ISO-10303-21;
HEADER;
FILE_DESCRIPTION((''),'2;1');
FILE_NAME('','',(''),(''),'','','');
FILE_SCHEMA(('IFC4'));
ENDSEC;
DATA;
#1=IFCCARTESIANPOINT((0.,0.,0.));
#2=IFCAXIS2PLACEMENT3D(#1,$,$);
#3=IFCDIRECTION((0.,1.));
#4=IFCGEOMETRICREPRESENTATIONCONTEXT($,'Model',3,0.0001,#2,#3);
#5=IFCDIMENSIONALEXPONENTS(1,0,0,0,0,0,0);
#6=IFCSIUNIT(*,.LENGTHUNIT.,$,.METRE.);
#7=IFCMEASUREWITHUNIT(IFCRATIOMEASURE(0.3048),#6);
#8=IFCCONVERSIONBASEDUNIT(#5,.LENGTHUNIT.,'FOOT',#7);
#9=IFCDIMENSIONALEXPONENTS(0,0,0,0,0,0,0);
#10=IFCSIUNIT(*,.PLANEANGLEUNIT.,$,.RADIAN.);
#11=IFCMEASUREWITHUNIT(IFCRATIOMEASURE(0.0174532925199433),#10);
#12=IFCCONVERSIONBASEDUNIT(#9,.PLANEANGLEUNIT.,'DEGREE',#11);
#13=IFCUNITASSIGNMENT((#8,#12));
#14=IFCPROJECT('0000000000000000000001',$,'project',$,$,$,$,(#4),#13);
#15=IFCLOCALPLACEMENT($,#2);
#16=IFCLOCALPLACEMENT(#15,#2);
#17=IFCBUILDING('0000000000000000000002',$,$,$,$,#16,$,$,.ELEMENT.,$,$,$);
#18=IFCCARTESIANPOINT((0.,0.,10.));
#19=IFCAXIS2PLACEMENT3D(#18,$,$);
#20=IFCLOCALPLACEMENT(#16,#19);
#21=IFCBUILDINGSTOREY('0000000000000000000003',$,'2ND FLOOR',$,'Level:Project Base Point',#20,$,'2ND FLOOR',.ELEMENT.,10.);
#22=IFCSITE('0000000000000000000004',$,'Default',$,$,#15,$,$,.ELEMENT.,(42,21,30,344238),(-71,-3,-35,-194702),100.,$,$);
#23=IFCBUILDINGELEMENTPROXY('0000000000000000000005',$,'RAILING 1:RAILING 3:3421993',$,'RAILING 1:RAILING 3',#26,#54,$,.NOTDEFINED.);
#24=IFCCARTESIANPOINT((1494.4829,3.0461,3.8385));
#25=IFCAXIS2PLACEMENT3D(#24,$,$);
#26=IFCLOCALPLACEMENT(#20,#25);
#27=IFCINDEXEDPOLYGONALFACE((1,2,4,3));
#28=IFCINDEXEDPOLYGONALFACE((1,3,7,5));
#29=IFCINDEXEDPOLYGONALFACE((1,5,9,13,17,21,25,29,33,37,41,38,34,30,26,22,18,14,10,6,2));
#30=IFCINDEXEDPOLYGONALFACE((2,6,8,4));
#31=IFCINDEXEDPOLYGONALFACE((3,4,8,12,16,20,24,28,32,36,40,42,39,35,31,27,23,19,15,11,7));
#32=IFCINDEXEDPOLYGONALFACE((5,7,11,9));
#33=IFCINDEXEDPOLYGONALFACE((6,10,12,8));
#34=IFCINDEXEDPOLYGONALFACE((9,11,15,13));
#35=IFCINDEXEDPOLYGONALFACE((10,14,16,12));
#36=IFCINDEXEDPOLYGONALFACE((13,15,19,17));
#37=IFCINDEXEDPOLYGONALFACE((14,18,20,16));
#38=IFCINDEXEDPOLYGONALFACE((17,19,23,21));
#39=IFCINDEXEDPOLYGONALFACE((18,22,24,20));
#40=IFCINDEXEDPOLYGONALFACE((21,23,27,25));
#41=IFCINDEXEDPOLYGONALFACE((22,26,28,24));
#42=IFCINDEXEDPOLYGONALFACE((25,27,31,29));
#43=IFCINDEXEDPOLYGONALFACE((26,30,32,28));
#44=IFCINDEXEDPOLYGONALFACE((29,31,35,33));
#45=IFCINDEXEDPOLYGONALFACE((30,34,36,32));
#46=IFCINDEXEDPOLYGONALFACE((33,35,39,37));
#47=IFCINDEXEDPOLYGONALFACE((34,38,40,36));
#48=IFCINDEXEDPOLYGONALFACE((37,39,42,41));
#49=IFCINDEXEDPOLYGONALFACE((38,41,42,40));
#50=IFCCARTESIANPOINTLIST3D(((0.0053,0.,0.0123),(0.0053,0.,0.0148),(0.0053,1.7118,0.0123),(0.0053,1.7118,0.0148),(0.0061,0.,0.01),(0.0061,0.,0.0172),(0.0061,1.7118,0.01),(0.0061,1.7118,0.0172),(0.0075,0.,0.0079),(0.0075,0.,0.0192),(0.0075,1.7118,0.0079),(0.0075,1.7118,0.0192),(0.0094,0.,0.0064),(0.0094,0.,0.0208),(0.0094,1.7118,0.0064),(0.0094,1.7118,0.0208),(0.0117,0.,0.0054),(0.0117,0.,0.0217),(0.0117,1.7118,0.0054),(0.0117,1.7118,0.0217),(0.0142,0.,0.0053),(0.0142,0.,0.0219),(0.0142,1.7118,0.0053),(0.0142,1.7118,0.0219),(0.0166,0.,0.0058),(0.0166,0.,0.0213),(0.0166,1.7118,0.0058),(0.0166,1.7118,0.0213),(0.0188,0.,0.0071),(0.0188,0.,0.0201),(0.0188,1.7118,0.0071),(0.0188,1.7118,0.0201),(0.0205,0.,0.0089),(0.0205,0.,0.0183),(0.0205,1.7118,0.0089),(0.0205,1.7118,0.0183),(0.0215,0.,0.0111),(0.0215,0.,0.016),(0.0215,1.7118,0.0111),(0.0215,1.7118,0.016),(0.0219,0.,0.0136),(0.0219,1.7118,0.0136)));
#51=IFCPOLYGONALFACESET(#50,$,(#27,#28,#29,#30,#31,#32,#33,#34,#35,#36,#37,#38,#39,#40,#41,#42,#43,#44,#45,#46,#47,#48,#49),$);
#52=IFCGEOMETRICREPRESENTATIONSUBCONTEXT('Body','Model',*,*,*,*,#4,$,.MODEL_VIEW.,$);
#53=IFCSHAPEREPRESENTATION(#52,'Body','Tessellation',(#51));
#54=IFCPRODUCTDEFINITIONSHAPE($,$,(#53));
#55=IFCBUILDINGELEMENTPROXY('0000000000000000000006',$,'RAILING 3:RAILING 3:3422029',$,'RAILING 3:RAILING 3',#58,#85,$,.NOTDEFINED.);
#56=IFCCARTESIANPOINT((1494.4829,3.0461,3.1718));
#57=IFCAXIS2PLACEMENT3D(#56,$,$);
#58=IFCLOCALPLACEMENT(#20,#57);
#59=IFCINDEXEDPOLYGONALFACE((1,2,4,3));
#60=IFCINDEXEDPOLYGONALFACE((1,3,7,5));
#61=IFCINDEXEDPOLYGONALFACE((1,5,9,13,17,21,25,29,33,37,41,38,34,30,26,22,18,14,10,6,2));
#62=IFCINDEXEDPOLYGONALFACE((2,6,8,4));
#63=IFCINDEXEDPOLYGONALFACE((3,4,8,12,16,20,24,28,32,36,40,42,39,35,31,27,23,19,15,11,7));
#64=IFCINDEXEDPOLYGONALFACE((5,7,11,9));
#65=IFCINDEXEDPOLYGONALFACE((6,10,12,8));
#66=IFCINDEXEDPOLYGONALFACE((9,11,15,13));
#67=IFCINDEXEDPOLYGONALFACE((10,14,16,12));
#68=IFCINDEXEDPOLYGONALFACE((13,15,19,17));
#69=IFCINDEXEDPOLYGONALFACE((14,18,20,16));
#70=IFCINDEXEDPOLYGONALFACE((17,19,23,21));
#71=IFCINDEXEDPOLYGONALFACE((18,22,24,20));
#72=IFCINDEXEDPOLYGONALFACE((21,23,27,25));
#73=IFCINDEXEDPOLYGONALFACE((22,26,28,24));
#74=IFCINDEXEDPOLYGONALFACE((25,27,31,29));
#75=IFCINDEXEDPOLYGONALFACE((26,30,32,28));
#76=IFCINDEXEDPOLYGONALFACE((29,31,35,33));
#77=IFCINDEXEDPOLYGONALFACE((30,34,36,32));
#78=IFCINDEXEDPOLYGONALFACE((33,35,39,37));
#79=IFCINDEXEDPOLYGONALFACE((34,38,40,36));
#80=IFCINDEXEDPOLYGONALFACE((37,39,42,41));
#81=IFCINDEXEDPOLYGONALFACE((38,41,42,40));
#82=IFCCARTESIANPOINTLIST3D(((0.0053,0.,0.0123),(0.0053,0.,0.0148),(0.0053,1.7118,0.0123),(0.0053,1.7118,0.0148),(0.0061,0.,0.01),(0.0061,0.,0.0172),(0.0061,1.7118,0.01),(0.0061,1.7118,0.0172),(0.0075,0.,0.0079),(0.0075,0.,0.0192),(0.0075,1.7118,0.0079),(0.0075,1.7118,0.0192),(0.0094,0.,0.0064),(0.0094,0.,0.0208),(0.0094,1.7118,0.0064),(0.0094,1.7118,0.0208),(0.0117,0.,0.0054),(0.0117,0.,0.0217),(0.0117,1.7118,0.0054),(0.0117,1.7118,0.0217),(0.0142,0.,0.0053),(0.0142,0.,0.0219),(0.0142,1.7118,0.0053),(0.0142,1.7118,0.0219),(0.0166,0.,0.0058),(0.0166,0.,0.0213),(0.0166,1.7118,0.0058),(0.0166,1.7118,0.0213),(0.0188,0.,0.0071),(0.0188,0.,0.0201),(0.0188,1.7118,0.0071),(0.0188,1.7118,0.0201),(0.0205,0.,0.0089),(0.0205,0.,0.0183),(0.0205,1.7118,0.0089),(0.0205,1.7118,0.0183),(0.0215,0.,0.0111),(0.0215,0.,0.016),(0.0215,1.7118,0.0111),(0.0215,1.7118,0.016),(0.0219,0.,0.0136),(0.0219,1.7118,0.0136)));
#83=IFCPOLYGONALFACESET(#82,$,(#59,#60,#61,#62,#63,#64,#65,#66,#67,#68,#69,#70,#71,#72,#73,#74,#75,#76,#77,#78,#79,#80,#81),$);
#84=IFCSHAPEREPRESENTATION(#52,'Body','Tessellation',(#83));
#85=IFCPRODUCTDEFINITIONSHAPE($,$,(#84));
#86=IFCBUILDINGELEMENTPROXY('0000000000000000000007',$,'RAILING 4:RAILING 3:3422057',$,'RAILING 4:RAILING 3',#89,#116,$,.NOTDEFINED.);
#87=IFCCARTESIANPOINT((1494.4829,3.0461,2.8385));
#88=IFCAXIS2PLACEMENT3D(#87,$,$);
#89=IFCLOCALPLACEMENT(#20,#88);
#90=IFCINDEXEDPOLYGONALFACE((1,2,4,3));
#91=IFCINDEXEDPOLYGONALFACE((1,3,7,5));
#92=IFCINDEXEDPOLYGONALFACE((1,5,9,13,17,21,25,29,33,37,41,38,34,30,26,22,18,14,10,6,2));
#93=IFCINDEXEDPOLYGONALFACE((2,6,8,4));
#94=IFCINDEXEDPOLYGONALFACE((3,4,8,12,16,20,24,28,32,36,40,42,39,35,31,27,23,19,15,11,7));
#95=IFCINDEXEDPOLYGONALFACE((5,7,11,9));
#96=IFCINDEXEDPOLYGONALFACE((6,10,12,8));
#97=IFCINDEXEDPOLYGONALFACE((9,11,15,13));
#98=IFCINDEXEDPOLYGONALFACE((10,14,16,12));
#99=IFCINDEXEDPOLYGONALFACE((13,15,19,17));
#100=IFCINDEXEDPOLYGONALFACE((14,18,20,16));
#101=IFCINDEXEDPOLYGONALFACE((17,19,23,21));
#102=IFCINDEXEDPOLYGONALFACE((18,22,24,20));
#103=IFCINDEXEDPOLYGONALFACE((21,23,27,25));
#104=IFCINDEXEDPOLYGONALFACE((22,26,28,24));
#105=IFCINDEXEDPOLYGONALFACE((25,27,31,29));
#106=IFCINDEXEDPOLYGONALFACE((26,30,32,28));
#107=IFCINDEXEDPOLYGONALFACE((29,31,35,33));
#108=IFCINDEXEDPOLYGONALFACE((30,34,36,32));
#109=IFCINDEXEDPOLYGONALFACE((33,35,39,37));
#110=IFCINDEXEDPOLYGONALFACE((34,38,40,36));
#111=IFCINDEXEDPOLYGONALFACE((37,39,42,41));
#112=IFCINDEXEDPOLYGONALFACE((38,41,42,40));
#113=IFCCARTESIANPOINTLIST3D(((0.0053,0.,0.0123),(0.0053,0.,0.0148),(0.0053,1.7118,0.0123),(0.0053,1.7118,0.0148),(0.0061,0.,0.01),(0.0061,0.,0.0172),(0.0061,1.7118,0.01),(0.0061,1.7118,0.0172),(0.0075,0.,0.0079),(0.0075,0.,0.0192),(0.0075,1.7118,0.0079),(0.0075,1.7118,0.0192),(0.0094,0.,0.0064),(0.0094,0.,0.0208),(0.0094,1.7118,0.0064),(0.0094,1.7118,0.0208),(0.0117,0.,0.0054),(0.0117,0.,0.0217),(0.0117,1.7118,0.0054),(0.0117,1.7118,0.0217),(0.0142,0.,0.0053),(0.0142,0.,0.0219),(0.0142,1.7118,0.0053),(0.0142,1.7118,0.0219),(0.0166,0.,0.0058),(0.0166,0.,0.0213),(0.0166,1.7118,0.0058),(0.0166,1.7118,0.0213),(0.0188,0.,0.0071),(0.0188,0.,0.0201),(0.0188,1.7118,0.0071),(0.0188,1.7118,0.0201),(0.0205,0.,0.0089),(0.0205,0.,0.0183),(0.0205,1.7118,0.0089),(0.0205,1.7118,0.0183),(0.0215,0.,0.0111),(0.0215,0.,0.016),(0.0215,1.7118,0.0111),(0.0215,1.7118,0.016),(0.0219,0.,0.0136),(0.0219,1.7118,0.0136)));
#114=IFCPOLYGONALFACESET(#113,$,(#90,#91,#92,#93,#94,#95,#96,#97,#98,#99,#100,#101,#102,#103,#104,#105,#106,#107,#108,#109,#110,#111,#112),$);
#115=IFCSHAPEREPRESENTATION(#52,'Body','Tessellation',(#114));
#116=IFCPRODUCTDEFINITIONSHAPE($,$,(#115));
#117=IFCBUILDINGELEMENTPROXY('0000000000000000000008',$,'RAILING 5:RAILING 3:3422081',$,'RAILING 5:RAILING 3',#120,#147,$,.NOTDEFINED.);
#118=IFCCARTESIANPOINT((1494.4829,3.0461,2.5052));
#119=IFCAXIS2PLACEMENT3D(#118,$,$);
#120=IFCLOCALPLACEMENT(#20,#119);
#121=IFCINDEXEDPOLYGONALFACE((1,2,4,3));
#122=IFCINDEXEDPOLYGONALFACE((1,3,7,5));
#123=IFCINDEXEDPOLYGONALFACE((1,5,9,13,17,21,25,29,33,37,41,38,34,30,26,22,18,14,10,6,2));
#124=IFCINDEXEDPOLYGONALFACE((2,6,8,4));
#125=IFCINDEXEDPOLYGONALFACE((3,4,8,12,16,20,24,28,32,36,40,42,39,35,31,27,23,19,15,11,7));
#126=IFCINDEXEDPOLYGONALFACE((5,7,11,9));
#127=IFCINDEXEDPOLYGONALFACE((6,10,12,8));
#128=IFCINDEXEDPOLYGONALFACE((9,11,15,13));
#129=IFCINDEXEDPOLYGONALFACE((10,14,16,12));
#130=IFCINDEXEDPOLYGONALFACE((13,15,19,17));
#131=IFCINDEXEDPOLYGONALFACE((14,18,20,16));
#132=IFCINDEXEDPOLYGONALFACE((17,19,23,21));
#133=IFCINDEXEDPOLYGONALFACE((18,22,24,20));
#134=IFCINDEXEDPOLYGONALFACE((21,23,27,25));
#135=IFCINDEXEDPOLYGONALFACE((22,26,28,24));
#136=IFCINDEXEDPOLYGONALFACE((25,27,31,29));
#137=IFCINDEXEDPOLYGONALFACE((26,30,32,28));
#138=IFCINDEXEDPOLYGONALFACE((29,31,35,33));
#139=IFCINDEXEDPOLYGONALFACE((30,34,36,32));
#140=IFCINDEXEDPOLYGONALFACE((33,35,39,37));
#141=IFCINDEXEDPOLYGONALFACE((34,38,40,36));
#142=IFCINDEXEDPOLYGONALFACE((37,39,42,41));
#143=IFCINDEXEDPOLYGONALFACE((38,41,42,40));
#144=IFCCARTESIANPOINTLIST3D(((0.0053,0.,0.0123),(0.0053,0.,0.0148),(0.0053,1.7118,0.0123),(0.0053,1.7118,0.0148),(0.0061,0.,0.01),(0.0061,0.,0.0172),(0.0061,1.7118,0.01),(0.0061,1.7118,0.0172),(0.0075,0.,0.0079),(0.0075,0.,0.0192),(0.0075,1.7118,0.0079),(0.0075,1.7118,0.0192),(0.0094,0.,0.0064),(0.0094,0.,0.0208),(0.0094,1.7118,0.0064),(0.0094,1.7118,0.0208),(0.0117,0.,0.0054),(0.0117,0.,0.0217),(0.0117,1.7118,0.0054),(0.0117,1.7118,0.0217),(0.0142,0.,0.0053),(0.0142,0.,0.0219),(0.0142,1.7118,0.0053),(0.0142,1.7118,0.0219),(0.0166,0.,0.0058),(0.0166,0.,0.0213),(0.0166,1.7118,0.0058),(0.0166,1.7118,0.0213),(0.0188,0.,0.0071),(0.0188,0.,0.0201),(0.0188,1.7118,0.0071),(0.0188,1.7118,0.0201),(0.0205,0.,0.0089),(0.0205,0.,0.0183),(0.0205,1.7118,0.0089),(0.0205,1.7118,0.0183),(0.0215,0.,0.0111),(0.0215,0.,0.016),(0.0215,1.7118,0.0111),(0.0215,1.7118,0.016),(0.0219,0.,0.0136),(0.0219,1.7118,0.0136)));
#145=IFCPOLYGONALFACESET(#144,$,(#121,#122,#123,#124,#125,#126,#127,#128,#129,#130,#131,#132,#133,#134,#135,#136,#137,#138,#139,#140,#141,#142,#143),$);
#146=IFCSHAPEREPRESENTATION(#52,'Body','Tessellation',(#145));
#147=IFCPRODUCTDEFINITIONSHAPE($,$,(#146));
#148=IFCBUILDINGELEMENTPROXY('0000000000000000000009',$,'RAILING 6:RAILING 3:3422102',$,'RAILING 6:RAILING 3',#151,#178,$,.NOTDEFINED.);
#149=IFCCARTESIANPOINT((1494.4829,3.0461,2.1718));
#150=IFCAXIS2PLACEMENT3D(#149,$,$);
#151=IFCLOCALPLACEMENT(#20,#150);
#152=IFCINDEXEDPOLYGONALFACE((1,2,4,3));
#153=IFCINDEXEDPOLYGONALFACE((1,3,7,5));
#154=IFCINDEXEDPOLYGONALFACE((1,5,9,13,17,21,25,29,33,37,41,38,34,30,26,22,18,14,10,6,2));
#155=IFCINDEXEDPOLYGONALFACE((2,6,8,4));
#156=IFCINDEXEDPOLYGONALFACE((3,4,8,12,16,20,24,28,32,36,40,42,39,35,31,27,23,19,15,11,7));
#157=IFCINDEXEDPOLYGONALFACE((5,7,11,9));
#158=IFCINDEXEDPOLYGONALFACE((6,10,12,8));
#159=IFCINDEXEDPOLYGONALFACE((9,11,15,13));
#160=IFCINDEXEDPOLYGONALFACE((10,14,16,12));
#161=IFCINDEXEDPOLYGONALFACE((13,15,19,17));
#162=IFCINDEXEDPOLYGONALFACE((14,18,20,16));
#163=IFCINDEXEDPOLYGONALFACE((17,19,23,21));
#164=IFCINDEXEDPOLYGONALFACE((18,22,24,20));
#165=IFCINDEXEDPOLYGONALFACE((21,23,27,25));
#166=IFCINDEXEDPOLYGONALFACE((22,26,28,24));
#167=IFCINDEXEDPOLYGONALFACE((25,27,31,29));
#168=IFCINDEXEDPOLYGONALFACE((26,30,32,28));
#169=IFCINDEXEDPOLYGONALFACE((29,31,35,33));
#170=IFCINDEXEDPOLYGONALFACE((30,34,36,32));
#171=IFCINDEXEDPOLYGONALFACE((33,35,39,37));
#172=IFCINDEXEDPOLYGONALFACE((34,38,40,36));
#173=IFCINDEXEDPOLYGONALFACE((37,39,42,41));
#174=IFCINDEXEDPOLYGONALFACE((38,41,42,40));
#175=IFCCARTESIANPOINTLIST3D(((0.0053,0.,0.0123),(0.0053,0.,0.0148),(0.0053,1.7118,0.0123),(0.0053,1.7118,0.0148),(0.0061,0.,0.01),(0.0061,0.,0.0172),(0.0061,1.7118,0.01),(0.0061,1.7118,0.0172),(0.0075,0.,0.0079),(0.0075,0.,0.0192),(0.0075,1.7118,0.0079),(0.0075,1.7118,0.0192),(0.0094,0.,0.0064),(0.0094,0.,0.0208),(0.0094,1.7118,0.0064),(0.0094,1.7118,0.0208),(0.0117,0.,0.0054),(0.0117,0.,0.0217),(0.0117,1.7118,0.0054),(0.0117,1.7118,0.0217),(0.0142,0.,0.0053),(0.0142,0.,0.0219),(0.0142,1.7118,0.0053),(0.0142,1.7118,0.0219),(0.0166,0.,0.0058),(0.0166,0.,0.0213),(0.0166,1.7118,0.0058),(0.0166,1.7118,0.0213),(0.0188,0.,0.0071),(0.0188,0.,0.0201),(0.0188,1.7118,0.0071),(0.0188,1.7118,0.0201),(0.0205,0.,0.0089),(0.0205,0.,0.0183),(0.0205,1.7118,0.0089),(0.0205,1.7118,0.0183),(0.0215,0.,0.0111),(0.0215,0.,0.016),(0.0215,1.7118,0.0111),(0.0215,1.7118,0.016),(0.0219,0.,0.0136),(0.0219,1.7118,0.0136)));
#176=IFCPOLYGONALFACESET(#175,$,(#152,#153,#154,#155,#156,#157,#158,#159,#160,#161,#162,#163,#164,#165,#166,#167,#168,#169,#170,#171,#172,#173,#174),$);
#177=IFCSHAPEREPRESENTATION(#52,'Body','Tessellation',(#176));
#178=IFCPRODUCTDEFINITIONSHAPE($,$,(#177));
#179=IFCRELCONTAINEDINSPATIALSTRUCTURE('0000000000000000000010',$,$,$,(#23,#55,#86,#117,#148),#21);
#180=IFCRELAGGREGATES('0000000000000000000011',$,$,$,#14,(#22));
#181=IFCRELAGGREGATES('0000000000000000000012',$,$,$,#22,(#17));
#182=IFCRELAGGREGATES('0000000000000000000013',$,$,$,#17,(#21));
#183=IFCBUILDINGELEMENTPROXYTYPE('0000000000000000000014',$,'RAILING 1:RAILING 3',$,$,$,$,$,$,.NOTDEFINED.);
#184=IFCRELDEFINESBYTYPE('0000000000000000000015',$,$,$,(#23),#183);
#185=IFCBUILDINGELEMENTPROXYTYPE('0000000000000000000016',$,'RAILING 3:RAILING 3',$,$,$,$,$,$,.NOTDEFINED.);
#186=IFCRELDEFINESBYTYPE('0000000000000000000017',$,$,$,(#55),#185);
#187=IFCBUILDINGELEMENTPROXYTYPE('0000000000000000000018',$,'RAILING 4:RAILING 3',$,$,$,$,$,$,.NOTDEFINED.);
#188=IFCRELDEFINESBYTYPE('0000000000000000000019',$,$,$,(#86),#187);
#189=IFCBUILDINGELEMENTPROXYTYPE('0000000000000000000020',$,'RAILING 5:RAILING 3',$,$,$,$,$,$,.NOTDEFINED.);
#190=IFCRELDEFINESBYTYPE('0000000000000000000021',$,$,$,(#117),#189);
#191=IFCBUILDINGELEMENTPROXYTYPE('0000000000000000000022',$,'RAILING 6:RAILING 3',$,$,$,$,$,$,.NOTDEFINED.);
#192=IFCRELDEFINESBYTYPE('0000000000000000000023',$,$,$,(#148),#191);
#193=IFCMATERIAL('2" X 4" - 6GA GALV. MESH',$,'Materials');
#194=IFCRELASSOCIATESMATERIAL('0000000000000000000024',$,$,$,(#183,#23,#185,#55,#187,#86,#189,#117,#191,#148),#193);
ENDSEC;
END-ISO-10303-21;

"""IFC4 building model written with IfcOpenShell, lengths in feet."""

from ifc_helpers import new_model, entity, si_unit, converted_unit, direction, frame, origin, origin_2d_with_axis, place, context, subcontext, project, spatial, circle, extrude, source, transform, mapped, material, type_object, type_shapes, element, save


model = new_model("IFC4")

# Units and contexts
model_context = context("Model", 3, precision=0.0001, world=origin(), true_north=direction((0.0, 1.0)))
body_context = subcontext(model_context, "Body", "Model", "MODEL_VIEW")
ifc_project = project(units=[converted_unit("LENGTHUNIT", "FOOT", entity("IfcRatioMeasure", 0.3048), si_unit("LENGTHUNIT", "METRE"), dimensions=[1, 0, 0, 0, 0, 0, 0]), converted_unit("PLANEANGLEUNIT", "DEGREE", entity("IfcRatioMeasure", 0.0174532925199433), si_unit("PLANEANGLEUNIT", "RADIAN"), dimensions=[0, 0, 0, 0, 0, 0, 0])], contexts=[model_context])

# Site, building, storey
site_placement = place(None, origin())
site = spatial("IfcSite", under=ifc_project, at=site_placement, Name="Default", CompositionType="ELEMENT", RefLatitude=(42, 21, 30, 344238), RefLongitude=(-71, -3, -35, -194702), RefElevation=100.0)
building_placement = place(site_placement, origin())
building = spatial("IfcBuilding", under=site, at=building_placement, CompositionType="ELEMENT")
storey_placement = place(building_placement, frame((0.0, 0.0, 10.0)))
storey = spatial("IfcBuildingStorey", under=building, at=storey_placement, Name="2ND FLOOR", ObjectType="Level:Project Base Point", LongName="2ND FLOOR", CompositionType="ELEMENT", Elevation=10.0)

# Building element proxies
ifc_material_1 = material(Name="2\" X 4\" - 6GA GALV. MESH", Category="Materials")
building_element_proxy_type_1 = type_object("IfcBuildingElementProxyType", Name="RAILING 1:RAILING 3", PredefinedType="NOTDEFINED", material=ifc_material_1)
shared_shape_1 = source(origin(), body_context, "Body", "SweptSolid", [
    extrude(circle(Radius=0.0083, at=origin_2d_with_axis()), frame((0.0136, 0.0, 0.0136), z_axis=(0.0, 1.0, 0.0), x_axis=(1.0, 0.0, 0.0)), (0.0, 0.0, 1.0), 1.7118),
])
type_shapes(building_element_proxy_type_1, [shared_shape_1])
proxy_1_placement = place(storey_placement, frame((1494.4829, 3.0461, 3.8385)))
element("IfcBuildingElementProxy", 1, at=proxy_1_placement, inside=storey, type_object=building_element_proxy_type_1, material=ifc_material_1, Name="RAILING 1:RAILING 3:3421993", ObjectType="RAILING 1:RAILING 3", PredefinedType="NOTDEFINED", context=body_context, shape_type="MappedRepresentation", body=[
    mapped(shared_shape_1, transform((0.0, 0.0, 0.0), scale=1.0)),
])
building_element_proxy_type_2 = type_object("IfcBuildingElementProxyType", Name="RAILING 3:RAILING 3", PredefinedType="NOTDEFINED", material=ifc_material_1)
shared_shape_2 = source(origin(), body_context, "Body", "SweptSolid", [
    extrude(circle(Radius=0.0083, at=origin_2d_with_axis()), frame((0.0136, 0.0, 0.0136), z_axis=(0.0, 1.0, 0.0), x_axis=(1.0, 0.0, 0.0)), (0.0, 0.0, 1.0), 1.7118),
])
type_shapes(building_element_proxy_type_2, [shared_shape_2])
proxy_2_placement = place(storey_placement, frame((1494.4829, 3.0461, 3.1718)))
element("IfcBuildingElementProxy", 2, at=proxy_2_placement, inside=storey, type_object=building_element_proxy_type_2, material=ifc_material_1, Name="RAILING 3:RAILING 3:3422029", ObjectType="RAILING 3:RAILING 3", PredefinedType="NOTDEFINED", context=body_context, shape_type="MappedRepresentation", body=[
    mapped(shared_shape_2, transform((0.0, 0.0, 0.0), scale=1.0)),
])
building_element_proxy_type_3 = type_object("IfcBuildingElementProxyType", Name="RAILING 4:RAILING 3", PredefinedType="NOTDEFINED", material=ifc_material_1)
shared_shape_3 = source(origin(), body_context, "Body", "SweptSolid", [
    extrude(circle(Radius=0.0083, at=origin_2d_with_axis()), frame((0.0136, 0.0, 0.0136), z_axis=(0.0, 1.0, 0.0), x_axis=(1.0, 0.0, 0.0)), (0.0, 0.0, 1.0), 1.7118),
])
type_shapes(building_element_proxy_type_3, [shared_shape_3])
proxy_3_placement = place(storey_placement, frame((1494.4829, 3.0461, 2.8385)))
element("IfcBuildingElementProxy", 3, at=proxy_3_placement, inside=storey, type_object=building_element_proxy_type_3, material=ifc_material_1, Name="RAILING 4:RAILING 3:3422057", ObjectType="RAILING 4:RAILING 3", PredefinedType="NOTDEFINED", context=body_context, shape_type="MappedRepresentation", body=[
    mapped(shared_shape_3, transform((0.0, 0.0, 0.0), scale=1.0)),
])
building_element_proxy_type_4 = type_object("IfcBuildingElementProxyType", Name="RAILING 5:RAILING 3", PredefinedType="NOTDEFINED", material=ifc_material_1)
shared_shape_4 = source(origin(), body_context, "Body", "SweptSolid", [
    extrude(circle(Radius=0.0083, at=origin_2d_with_axis()), frame((0.0136, 0.0, 0.0136), z_axis=(0.0, 1.0, 0.0), x_axis=(1.0, 0.0, 0.0)), (0.0, 0.0, 1.0), 1.7118),
])
type_shapes(building_element_proxy_type_4, [shared_shape_4])
proxy_4_placement = place(storey_placement, frame((1494.4829, 3.0461, 2.5052)))
element("IfcBuildingElementProxy", 4, at=proxy_4_placement, inside=storey, type_object=building_element_proxy_type_4, material=ifc_material_1, Name="RAILING 5:RAILING 3:3422081", ObjectType="RAILING 5:RAILING 3", PredefinedType="NOTDEFINED", context=body_context, shape_type="MappedRepresentation", body=[
    mapped(shared_shape_4, transform((0.0, 0.0, 0.0), scale=1.0)),
])
building_element_proxy_type_5 = type_object("IfcBuildingElementProxyType", Name="RAILING 6:RAILING 3", PredefinedType="NOTDEFINED", material=ifc_material_1)
shared_shape_5 = source(origin(), body_context, "Body", "SweptSolid", [
    extrude(circle(Radius=0.0083, at=origin_2d_with_axis()), frame((0.0136, 0.0, 0.0136), z_axis=(0.0, 1.0, 0.0), x_axis=(1.0, 0.0, 0.0)), (0.0, 0.0, 1.0), 1.7118),
])
type_shapes(building_element_proxy_type_5, [shared_shape_5])
proxy_5_placement = place(storey_placement, frame((1494.4829, 3.0461, 2.1718)))
element("IfcBuildingElementProxy", 5, at=proxy_5_placement, inside=storey, type_object=building_element_proxy_type_5, material=ifc_material_1, Name="RAILING 6:RAILING 3:3422102", ObjectType="RAILING 6:RAILING 3", PredefinedType="NOTDEFINED", context=body_context, shape_type="MappedRepresentation", body=[
    mapped(shared_shape_5, transform((0.0, 0.0, 0.0), scale=1.0)),
])

save(model, "model.ifc")
